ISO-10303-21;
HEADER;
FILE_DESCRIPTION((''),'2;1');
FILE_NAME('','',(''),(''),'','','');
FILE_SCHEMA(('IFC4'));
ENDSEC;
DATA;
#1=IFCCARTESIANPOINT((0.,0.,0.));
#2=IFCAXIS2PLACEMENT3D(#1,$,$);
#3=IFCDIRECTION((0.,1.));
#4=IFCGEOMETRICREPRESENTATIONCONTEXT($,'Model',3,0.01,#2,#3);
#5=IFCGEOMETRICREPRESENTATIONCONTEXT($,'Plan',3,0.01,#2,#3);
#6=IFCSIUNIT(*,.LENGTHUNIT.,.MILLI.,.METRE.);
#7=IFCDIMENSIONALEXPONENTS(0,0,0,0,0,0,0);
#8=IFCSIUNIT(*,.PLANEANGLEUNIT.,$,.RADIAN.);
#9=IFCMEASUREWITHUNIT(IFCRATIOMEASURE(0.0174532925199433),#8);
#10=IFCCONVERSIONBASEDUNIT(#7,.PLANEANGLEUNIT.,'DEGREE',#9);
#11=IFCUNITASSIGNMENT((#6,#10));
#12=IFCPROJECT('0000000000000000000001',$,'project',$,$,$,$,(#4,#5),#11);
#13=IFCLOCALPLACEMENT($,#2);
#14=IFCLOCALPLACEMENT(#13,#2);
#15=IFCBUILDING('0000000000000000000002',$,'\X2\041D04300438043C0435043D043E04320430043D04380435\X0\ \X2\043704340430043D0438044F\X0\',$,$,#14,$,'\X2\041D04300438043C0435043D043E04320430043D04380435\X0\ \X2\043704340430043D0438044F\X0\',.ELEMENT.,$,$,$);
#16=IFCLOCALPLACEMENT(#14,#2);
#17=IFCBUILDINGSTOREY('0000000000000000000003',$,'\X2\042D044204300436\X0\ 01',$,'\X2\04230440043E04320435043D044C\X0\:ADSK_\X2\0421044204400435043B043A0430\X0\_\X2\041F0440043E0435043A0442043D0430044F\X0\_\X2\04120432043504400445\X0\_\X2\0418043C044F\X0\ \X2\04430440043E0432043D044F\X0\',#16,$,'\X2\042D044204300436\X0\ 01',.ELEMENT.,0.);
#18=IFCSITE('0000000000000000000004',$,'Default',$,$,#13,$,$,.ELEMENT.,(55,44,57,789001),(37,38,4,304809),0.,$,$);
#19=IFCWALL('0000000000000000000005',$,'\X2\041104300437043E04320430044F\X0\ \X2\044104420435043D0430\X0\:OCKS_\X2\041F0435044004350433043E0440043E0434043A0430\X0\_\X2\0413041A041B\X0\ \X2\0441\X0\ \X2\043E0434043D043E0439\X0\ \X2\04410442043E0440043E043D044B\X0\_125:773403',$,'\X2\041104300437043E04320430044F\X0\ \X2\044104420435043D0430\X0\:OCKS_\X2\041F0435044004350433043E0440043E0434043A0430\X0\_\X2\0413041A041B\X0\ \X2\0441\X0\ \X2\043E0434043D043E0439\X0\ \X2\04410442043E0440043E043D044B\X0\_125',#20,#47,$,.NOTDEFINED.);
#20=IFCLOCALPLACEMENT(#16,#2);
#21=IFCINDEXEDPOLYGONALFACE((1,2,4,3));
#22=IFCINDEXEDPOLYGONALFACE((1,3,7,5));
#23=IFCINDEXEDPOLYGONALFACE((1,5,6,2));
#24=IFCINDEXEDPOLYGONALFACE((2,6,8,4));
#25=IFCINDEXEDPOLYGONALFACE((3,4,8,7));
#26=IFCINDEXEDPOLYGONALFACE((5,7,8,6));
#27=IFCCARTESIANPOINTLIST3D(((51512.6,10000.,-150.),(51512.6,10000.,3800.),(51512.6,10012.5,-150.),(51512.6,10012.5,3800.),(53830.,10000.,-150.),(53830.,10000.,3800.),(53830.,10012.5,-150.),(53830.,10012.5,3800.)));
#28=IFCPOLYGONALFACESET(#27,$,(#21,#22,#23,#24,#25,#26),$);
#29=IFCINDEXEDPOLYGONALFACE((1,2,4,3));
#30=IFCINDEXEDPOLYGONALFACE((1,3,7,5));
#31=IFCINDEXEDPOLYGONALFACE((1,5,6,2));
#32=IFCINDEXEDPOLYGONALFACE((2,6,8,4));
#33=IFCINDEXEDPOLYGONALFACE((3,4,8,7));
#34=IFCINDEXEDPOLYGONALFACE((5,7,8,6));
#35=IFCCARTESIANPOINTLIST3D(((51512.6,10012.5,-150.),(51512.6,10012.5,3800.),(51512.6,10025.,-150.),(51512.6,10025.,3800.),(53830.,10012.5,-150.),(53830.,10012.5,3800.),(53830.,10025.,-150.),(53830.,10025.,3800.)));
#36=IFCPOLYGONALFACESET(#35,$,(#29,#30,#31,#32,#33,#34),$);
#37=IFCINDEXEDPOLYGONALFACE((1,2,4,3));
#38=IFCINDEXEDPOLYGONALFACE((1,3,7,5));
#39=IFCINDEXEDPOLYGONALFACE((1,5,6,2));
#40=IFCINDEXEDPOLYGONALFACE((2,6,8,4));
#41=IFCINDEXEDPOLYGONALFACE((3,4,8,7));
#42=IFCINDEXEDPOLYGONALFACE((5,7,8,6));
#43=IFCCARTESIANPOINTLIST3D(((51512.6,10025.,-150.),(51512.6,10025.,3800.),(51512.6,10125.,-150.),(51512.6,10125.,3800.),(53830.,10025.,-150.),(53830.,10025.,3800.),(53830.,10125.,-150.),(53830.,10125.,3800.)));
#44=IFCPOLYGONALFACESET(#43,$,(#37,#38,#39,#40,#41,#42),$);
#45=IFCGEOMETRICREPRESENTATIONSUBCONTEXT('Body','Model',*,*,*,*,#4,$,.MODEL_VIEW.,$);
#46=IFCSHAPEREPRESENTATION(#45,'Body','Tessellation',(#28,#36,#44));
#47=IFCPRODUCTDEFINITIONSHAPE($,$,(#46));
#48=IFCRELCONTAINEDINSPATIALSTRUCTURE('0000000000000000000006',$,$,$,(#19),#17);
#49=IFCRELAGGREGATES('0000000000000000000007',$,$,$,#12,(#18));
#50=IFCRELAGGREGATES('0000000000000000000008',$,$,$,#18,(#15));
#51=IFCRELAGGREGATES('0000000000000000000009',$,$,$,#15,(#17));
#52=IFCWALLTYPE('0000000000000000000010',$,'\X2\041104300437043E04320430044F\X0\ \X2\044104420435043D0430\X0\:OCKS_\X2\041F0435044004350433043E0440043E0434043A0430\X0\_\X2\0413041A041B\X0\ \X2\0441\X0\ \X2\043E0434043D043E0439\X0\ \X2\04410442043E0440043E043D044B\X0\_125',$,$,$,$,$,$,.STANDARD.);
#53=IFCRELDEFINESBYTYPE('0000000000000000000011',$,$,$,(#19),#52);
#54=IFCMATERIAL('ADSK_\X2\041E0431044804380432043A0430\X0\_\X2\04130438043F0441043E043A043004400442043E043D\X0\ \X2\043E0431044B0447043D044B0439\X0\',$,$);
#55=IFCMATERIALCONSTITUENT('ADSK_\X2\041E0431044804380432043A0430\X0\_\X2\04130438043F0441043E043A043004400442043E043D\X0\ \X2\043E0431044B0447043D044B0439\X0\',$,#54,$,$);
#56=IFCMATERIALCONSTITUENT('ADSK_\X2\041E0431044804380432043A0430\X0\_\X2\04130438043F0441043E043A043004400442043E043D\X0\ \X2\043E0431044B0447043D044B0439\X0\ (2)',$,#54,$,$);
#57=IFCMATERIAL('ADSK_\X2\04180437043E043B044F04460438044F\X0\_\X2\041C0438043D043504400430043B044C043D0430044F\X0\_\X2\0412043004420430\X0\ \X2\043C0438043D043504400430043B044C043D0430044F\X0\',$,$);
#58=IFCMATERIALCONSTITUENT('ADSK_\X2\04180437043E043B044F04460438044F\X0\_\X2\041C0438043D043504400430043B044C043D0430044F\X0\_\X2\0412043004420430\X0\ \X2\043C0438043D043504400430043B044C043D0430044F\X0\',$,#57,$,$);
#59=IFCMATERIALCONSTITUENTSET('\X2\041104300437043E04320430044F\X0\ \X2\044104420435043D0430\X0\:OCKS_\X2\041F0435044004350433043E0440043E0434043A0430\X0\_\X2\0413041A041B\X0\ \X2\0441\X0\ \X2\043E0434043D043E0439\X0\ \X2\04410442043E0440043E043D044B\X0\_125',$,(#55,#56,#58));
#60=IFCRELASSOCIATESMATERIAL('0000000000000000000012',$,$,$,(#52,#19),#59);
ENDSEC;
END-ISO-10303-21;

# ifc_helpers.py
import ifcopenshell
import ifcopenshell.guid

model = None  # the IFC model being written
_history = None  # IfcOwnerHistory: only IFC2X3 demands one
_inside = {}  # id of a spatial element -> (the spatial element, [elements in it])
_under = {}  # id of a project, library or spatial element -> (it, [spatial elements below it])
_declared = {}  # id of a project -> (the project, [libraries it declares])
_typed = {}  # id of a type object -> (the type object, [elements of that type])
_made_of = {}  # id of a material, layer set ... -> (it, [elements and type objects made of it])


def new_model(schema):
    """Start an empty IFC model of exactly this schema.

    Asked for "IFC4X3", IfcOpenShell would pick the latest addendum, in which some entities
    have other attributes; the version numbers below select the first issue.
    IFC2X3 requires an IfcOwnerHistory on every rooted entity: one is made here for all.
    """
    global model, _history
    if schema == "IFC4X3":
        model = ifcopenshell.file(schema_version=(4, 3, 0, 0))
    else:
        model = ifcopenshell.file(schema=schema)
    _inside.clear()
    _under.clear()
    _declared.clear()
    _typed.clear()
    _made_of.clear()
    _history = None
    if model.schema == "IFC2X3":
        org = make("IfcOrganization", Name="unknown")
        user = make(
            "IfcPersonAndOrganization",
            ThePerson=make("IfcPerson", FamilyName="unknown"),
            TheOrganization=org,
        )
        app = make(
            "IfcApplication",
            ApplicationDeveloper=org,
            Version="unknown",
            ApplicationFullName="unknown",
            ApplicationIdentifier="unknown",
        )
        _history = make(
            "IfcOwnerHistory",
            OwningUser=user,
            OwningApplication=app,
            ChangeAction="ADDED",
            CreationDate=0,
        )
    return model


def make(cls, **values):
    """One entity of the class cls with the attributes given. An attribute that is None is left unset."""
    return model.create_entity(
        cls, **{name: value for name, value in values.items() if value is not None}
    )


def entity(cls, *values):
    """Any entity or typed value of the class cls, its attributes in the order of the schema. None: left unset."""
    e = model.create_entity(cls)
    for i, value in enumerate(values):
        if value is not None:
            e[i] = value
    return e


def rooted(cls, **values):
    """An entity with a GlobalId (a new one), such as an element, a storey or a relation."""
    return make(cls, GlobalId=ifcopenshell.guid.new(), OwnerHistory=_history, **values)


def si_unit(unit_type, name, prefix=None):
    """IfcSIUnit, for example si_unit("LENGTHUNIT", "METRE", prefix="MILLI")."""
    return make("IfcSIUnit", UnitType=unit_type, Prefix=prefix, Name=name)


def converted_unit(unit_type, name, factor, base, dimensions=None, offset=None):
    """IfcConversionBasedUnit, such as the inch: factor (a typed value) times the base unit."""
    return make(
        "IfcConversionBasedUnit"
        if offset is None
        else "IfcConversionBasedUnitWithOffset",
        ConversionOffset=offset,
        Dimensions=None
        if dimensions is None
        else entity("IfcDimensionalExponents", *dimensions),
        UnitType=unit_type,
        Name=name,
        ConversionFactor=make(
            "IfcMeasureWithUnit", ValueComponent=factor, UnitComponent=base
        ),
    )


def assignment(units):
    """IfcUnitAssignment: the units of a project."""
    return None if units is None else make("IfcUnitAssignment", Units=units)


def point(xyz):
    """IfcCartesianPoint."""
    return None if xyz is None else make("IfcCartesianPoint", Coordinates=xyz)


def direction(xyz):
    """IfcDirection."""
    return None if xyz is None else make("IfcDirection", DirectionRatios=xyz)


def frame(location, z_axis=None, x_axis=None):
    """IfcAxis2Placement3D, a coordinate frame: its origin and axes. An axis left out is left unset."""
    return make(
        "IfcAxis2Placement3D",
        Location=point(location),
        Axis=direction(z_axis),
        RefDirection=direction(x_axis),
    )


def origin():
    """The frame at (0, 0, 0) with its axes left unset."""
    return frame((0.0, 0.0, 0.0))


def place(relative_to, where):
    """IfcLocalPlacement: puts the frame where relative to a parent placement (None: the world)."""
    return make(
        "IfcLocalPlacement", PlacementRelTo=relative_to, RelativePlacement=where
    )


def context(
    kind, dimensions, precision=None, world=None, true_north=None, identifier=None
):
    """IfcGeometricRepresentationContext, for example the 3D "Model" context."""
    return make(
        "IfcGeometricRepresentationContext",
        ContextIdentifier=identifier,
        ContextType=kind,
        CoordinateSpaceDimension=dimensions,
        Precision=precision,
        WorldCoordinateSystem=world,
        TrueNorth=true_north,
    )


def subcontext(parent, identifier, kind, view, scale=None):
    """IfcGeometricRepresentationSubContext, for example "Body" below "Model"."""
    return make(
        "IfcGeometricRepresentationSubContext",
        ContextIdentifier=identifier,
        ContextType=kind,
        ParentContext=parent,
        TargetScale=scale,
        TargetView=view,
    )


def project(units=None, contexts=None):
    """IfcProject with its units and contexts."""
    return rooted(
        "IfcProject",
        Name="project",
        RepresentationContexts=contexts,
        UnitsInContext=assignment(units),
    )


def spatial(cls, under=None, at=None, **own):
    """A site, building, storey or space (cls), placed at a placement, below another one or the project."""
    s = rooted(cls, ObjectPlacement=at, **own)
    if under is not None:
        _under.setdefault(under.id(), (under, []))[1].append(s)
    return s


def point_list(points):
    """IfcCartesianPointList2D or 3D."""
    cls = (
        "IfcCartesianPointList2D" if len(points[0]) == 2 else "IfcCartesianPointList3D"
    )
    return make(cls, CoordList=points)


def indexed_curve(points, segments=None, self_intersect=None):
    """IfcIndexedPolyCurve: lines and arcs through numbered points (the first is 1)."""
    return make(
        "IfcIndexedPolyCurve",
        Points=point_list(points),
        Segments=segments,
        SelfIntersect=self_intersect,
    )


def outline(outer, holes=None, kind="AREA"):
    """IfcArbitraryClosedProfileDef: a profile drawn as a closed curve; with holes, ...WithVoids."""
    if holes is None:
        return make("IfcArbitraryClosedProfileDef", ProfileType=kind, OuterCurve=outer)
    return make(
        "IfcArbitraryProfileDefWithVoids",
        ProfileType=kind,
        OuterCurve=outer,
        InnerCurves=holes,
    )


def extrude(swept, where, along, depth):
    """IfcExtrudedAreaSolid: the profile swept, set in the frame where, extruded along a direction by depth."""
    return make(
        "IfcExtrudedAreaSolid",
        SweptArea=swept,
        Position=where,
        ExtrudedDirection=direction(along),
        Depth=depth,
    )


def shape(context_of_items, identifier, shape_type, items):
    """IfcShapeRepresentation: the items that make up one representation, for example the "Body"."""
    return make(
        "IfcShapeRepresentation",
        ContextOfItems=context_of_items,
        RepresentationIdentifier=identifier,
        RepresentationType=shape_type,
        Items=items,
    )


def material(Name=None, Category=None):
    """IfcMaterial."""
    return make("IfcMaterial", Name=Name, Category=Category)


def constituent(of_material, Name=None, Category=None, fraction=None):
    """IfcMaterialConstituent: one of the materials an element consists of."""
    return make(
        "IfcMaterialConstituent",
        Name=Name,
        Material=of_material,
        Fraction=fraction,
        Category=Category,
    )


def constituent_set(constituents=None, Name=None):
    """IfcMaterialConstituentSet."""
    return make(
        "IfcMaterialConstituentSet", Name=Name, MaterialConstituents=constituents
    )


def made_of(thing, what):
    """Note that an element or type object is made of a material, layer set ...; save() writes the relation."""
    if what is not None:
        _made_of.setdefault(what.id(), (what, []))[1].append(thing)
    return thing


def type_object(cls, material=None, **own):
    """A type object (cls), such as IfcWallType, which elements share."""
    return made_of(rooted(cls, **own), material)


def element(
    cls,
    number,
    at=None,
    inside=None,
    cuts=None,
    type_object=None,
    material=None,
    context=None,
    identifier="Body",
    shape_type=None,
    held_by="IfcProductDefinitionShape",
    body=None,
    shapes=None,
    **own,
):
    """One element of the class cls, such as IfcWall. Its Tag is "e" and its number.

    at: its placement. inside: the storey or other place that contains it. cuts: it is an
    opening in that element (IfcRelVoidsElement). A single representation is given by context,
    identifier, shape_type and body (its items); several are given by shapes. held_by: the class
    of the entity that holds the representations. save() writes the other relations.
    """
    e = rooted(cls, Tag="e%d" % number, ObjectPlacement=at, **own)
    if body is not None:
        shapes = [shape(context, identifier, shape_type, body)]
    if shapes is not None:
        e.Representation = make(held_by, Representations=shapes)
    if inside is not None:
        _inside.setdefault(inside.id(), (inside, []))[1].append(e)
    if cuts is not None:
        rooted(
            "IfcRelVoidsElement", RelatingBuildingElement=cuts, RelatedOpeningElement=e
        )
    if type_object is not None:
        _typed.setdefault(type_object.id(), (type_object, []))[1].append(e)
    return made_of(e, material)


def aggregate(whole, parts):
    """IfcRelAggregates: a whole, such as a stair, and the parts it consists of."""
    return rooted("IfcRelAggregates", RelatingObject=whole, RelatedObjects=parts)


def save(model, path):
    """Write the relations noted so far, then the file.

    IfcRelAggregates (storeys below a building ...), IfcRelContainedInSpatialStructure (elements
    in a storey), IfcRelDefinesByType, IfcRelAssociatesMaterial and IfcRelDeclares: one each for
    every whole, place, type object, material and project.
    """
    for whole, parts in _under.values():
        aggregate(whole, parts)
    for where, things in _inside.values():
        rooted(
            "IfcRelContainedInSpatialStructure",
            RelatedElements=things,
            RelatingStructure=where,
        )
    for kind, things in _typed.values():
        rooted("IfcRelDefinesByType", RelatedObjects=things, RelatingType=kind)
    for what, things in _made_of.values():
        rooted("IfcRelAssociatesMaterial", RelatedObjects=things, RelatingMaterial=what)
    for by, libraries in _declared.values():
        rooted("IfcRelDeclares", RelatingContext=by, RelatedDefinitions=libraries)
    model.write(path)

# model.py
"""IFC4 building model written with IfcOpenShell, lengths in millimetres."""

from ifc_helpers import new_model, entity, si_unit, converted_unit, direction, frame, origin, place, context, subcontext, project, spatial, indexed_curve, outline, extrude, material, constituent, constituent_set, type_object, element, save


model = new_model("IFC4")

# Units and contexts
model_context = context("Model", 3, precision=0.01, world=origin(), true_north=direction((0.0, 1.0)))
plan_context = context("Plan", 3, precision=0.01, world=origin(), true_north=direction((0.0, 1.0)))
body_context = subcontext(model_context, "Body", "Model", "MODEL_VIEW")
ifc_project = project(units=[si_unit("LENGTHUNIT", "METRE", prefix="MILLI"), converted_unit("PLANEANGLEUNIT", "DEGREE", entity("IfcRatioMeasure", 0.0174532925199433), si_unit("PLANEANGLEUNIT", "RADIAN"), dimensions=[0, 0, 0, 0, 0, 0, 0])], contexts=[model_context, plan_context])

# Site, building, storey
site_placement = place(None, frame((0.0, 0.0, 0.0)))
site = spatial("IfcSite", under=ifc_project, at=site_placement, Name="Default", CompositionType="ELEMENT", RefLatitude=(55, 44, 57, 789001), RefLongitude=(37, 38, 4, 304809), RefElevation=0.0)
building_placement = place(site_placement, origin())
building = spatial("IfcBuilding", under=site, at=building_placement, Name="Наименование здания", LongName="Наименование здания", CompositionType="ELEMENT")
storey_placement = place(building_placement, origin())
storey = spatial("IfcBuildingStorey", under=building, at=storey_placement, Name="Этаж 01", ObjectType="Уровень:ADSK_Стрелка_Проектная_Вверх_Имя уровня", LongName="Этаж 01", CompositionType="ELEMENT", Elevation=0.0)

# Shared definitions
ifc_material_1 = material(Name="ADSK_Обшивка_Гипсокартон обычный")
ifc_material_2 = material(Name="ADSK_Изоляция_Минеральная_Вата минеральная")

# Wall
ifc_constituent_1 = constituent(ifc_material_1, Name="ADSK_Обшивка_Гипсокартон обычный")
ifc_constituent_2 = constituent(ifc_material_1, Name="ADSK_Обшивка_Гипсокартон обычный (2)")
ifc_constituent_3 = constituent(ifc_material_2, Name="ADSK_Изоляция_Минеральная_Вата минеральная")
ifc_constituent_set_1 = constituent_set(constituents=[ifc_constituent_1, ifc_constituent_2, ifc_constituent_3], Name="Базовая стена:OCKS_Перегородка_ГКЛ с одной стороны_125")
wall_type_1 = type_object("IfcWallType", Name="Базовая стена:OCKS_Перегородка_ГКЛ с одной стороны_125", PredefinedType="STANDARD", material=ifc_constituent_set_1)
wall_1_placement = place(storey_placement, frame((53830.0, 10062.5, -150.0), z_axis=(0.0, 0.0, 1.0), x_axis=(-1.0, 0.0, 0.0)))
element("IfcWall", 1, at=wall_1_placement, inside=storey, type_object=wall_type_1, material=ifc_constituent_set_1, Name="Базовая стена:OCKS_Перегородка_ГКЛ с одной стороны_125:773403", ObjectType="Базовая стена:OCKS_Перегородка_ГКЛ с одной стороны_125", PredefinedType="NOTDEFINED", context=body_context, shape_type="SweptSolid", body=[
    extrude(outline(indexed_curve([(-6.3, -1158.7), (6.2, -1158.7), (6.3, 1158.7), (-6.2, 1158.7), (-6.3, -1158.7)], self_intersect=False)), frame((1158.7, 56.2, 0.0), z_axis=(0.0, 0.0, 1.0), x_axis=(0.0, 1.0, 0.0)), (0.0, 0.0, 1.0), 3950.0),
    extrude(outline(indexed_curve([(-6.3, -1158.7), (6.2, -1158.7), (6.3, 1158.7), (-6.2, 1158.7), (-6.3, -1158.7)], self_intersect=False)), frame((1158.7, 43.7, 0.0), z_axis=(0.0, 0.0, 1.0), x_axis=(0.0, 1.0, 0.0)), (0.0, 0.0, 1.0), 3950.0),
    extrude(outline(indexed_curve([(-50.0, -1158.7), (50.0, -1158.7), (50.0, 1158.7), (-50.0, 1158.7), (-50.0, -1158.7)], self_intersect=False)), frame((1158.7, -12.5, 0.0), z_axis=(0.0, 0.0, 1.0), x_axis=(0.0, -1.0, 0.0)), (0.0, 0.0, 1.0), 3950.0),
])

save(model, "model.ifc")
